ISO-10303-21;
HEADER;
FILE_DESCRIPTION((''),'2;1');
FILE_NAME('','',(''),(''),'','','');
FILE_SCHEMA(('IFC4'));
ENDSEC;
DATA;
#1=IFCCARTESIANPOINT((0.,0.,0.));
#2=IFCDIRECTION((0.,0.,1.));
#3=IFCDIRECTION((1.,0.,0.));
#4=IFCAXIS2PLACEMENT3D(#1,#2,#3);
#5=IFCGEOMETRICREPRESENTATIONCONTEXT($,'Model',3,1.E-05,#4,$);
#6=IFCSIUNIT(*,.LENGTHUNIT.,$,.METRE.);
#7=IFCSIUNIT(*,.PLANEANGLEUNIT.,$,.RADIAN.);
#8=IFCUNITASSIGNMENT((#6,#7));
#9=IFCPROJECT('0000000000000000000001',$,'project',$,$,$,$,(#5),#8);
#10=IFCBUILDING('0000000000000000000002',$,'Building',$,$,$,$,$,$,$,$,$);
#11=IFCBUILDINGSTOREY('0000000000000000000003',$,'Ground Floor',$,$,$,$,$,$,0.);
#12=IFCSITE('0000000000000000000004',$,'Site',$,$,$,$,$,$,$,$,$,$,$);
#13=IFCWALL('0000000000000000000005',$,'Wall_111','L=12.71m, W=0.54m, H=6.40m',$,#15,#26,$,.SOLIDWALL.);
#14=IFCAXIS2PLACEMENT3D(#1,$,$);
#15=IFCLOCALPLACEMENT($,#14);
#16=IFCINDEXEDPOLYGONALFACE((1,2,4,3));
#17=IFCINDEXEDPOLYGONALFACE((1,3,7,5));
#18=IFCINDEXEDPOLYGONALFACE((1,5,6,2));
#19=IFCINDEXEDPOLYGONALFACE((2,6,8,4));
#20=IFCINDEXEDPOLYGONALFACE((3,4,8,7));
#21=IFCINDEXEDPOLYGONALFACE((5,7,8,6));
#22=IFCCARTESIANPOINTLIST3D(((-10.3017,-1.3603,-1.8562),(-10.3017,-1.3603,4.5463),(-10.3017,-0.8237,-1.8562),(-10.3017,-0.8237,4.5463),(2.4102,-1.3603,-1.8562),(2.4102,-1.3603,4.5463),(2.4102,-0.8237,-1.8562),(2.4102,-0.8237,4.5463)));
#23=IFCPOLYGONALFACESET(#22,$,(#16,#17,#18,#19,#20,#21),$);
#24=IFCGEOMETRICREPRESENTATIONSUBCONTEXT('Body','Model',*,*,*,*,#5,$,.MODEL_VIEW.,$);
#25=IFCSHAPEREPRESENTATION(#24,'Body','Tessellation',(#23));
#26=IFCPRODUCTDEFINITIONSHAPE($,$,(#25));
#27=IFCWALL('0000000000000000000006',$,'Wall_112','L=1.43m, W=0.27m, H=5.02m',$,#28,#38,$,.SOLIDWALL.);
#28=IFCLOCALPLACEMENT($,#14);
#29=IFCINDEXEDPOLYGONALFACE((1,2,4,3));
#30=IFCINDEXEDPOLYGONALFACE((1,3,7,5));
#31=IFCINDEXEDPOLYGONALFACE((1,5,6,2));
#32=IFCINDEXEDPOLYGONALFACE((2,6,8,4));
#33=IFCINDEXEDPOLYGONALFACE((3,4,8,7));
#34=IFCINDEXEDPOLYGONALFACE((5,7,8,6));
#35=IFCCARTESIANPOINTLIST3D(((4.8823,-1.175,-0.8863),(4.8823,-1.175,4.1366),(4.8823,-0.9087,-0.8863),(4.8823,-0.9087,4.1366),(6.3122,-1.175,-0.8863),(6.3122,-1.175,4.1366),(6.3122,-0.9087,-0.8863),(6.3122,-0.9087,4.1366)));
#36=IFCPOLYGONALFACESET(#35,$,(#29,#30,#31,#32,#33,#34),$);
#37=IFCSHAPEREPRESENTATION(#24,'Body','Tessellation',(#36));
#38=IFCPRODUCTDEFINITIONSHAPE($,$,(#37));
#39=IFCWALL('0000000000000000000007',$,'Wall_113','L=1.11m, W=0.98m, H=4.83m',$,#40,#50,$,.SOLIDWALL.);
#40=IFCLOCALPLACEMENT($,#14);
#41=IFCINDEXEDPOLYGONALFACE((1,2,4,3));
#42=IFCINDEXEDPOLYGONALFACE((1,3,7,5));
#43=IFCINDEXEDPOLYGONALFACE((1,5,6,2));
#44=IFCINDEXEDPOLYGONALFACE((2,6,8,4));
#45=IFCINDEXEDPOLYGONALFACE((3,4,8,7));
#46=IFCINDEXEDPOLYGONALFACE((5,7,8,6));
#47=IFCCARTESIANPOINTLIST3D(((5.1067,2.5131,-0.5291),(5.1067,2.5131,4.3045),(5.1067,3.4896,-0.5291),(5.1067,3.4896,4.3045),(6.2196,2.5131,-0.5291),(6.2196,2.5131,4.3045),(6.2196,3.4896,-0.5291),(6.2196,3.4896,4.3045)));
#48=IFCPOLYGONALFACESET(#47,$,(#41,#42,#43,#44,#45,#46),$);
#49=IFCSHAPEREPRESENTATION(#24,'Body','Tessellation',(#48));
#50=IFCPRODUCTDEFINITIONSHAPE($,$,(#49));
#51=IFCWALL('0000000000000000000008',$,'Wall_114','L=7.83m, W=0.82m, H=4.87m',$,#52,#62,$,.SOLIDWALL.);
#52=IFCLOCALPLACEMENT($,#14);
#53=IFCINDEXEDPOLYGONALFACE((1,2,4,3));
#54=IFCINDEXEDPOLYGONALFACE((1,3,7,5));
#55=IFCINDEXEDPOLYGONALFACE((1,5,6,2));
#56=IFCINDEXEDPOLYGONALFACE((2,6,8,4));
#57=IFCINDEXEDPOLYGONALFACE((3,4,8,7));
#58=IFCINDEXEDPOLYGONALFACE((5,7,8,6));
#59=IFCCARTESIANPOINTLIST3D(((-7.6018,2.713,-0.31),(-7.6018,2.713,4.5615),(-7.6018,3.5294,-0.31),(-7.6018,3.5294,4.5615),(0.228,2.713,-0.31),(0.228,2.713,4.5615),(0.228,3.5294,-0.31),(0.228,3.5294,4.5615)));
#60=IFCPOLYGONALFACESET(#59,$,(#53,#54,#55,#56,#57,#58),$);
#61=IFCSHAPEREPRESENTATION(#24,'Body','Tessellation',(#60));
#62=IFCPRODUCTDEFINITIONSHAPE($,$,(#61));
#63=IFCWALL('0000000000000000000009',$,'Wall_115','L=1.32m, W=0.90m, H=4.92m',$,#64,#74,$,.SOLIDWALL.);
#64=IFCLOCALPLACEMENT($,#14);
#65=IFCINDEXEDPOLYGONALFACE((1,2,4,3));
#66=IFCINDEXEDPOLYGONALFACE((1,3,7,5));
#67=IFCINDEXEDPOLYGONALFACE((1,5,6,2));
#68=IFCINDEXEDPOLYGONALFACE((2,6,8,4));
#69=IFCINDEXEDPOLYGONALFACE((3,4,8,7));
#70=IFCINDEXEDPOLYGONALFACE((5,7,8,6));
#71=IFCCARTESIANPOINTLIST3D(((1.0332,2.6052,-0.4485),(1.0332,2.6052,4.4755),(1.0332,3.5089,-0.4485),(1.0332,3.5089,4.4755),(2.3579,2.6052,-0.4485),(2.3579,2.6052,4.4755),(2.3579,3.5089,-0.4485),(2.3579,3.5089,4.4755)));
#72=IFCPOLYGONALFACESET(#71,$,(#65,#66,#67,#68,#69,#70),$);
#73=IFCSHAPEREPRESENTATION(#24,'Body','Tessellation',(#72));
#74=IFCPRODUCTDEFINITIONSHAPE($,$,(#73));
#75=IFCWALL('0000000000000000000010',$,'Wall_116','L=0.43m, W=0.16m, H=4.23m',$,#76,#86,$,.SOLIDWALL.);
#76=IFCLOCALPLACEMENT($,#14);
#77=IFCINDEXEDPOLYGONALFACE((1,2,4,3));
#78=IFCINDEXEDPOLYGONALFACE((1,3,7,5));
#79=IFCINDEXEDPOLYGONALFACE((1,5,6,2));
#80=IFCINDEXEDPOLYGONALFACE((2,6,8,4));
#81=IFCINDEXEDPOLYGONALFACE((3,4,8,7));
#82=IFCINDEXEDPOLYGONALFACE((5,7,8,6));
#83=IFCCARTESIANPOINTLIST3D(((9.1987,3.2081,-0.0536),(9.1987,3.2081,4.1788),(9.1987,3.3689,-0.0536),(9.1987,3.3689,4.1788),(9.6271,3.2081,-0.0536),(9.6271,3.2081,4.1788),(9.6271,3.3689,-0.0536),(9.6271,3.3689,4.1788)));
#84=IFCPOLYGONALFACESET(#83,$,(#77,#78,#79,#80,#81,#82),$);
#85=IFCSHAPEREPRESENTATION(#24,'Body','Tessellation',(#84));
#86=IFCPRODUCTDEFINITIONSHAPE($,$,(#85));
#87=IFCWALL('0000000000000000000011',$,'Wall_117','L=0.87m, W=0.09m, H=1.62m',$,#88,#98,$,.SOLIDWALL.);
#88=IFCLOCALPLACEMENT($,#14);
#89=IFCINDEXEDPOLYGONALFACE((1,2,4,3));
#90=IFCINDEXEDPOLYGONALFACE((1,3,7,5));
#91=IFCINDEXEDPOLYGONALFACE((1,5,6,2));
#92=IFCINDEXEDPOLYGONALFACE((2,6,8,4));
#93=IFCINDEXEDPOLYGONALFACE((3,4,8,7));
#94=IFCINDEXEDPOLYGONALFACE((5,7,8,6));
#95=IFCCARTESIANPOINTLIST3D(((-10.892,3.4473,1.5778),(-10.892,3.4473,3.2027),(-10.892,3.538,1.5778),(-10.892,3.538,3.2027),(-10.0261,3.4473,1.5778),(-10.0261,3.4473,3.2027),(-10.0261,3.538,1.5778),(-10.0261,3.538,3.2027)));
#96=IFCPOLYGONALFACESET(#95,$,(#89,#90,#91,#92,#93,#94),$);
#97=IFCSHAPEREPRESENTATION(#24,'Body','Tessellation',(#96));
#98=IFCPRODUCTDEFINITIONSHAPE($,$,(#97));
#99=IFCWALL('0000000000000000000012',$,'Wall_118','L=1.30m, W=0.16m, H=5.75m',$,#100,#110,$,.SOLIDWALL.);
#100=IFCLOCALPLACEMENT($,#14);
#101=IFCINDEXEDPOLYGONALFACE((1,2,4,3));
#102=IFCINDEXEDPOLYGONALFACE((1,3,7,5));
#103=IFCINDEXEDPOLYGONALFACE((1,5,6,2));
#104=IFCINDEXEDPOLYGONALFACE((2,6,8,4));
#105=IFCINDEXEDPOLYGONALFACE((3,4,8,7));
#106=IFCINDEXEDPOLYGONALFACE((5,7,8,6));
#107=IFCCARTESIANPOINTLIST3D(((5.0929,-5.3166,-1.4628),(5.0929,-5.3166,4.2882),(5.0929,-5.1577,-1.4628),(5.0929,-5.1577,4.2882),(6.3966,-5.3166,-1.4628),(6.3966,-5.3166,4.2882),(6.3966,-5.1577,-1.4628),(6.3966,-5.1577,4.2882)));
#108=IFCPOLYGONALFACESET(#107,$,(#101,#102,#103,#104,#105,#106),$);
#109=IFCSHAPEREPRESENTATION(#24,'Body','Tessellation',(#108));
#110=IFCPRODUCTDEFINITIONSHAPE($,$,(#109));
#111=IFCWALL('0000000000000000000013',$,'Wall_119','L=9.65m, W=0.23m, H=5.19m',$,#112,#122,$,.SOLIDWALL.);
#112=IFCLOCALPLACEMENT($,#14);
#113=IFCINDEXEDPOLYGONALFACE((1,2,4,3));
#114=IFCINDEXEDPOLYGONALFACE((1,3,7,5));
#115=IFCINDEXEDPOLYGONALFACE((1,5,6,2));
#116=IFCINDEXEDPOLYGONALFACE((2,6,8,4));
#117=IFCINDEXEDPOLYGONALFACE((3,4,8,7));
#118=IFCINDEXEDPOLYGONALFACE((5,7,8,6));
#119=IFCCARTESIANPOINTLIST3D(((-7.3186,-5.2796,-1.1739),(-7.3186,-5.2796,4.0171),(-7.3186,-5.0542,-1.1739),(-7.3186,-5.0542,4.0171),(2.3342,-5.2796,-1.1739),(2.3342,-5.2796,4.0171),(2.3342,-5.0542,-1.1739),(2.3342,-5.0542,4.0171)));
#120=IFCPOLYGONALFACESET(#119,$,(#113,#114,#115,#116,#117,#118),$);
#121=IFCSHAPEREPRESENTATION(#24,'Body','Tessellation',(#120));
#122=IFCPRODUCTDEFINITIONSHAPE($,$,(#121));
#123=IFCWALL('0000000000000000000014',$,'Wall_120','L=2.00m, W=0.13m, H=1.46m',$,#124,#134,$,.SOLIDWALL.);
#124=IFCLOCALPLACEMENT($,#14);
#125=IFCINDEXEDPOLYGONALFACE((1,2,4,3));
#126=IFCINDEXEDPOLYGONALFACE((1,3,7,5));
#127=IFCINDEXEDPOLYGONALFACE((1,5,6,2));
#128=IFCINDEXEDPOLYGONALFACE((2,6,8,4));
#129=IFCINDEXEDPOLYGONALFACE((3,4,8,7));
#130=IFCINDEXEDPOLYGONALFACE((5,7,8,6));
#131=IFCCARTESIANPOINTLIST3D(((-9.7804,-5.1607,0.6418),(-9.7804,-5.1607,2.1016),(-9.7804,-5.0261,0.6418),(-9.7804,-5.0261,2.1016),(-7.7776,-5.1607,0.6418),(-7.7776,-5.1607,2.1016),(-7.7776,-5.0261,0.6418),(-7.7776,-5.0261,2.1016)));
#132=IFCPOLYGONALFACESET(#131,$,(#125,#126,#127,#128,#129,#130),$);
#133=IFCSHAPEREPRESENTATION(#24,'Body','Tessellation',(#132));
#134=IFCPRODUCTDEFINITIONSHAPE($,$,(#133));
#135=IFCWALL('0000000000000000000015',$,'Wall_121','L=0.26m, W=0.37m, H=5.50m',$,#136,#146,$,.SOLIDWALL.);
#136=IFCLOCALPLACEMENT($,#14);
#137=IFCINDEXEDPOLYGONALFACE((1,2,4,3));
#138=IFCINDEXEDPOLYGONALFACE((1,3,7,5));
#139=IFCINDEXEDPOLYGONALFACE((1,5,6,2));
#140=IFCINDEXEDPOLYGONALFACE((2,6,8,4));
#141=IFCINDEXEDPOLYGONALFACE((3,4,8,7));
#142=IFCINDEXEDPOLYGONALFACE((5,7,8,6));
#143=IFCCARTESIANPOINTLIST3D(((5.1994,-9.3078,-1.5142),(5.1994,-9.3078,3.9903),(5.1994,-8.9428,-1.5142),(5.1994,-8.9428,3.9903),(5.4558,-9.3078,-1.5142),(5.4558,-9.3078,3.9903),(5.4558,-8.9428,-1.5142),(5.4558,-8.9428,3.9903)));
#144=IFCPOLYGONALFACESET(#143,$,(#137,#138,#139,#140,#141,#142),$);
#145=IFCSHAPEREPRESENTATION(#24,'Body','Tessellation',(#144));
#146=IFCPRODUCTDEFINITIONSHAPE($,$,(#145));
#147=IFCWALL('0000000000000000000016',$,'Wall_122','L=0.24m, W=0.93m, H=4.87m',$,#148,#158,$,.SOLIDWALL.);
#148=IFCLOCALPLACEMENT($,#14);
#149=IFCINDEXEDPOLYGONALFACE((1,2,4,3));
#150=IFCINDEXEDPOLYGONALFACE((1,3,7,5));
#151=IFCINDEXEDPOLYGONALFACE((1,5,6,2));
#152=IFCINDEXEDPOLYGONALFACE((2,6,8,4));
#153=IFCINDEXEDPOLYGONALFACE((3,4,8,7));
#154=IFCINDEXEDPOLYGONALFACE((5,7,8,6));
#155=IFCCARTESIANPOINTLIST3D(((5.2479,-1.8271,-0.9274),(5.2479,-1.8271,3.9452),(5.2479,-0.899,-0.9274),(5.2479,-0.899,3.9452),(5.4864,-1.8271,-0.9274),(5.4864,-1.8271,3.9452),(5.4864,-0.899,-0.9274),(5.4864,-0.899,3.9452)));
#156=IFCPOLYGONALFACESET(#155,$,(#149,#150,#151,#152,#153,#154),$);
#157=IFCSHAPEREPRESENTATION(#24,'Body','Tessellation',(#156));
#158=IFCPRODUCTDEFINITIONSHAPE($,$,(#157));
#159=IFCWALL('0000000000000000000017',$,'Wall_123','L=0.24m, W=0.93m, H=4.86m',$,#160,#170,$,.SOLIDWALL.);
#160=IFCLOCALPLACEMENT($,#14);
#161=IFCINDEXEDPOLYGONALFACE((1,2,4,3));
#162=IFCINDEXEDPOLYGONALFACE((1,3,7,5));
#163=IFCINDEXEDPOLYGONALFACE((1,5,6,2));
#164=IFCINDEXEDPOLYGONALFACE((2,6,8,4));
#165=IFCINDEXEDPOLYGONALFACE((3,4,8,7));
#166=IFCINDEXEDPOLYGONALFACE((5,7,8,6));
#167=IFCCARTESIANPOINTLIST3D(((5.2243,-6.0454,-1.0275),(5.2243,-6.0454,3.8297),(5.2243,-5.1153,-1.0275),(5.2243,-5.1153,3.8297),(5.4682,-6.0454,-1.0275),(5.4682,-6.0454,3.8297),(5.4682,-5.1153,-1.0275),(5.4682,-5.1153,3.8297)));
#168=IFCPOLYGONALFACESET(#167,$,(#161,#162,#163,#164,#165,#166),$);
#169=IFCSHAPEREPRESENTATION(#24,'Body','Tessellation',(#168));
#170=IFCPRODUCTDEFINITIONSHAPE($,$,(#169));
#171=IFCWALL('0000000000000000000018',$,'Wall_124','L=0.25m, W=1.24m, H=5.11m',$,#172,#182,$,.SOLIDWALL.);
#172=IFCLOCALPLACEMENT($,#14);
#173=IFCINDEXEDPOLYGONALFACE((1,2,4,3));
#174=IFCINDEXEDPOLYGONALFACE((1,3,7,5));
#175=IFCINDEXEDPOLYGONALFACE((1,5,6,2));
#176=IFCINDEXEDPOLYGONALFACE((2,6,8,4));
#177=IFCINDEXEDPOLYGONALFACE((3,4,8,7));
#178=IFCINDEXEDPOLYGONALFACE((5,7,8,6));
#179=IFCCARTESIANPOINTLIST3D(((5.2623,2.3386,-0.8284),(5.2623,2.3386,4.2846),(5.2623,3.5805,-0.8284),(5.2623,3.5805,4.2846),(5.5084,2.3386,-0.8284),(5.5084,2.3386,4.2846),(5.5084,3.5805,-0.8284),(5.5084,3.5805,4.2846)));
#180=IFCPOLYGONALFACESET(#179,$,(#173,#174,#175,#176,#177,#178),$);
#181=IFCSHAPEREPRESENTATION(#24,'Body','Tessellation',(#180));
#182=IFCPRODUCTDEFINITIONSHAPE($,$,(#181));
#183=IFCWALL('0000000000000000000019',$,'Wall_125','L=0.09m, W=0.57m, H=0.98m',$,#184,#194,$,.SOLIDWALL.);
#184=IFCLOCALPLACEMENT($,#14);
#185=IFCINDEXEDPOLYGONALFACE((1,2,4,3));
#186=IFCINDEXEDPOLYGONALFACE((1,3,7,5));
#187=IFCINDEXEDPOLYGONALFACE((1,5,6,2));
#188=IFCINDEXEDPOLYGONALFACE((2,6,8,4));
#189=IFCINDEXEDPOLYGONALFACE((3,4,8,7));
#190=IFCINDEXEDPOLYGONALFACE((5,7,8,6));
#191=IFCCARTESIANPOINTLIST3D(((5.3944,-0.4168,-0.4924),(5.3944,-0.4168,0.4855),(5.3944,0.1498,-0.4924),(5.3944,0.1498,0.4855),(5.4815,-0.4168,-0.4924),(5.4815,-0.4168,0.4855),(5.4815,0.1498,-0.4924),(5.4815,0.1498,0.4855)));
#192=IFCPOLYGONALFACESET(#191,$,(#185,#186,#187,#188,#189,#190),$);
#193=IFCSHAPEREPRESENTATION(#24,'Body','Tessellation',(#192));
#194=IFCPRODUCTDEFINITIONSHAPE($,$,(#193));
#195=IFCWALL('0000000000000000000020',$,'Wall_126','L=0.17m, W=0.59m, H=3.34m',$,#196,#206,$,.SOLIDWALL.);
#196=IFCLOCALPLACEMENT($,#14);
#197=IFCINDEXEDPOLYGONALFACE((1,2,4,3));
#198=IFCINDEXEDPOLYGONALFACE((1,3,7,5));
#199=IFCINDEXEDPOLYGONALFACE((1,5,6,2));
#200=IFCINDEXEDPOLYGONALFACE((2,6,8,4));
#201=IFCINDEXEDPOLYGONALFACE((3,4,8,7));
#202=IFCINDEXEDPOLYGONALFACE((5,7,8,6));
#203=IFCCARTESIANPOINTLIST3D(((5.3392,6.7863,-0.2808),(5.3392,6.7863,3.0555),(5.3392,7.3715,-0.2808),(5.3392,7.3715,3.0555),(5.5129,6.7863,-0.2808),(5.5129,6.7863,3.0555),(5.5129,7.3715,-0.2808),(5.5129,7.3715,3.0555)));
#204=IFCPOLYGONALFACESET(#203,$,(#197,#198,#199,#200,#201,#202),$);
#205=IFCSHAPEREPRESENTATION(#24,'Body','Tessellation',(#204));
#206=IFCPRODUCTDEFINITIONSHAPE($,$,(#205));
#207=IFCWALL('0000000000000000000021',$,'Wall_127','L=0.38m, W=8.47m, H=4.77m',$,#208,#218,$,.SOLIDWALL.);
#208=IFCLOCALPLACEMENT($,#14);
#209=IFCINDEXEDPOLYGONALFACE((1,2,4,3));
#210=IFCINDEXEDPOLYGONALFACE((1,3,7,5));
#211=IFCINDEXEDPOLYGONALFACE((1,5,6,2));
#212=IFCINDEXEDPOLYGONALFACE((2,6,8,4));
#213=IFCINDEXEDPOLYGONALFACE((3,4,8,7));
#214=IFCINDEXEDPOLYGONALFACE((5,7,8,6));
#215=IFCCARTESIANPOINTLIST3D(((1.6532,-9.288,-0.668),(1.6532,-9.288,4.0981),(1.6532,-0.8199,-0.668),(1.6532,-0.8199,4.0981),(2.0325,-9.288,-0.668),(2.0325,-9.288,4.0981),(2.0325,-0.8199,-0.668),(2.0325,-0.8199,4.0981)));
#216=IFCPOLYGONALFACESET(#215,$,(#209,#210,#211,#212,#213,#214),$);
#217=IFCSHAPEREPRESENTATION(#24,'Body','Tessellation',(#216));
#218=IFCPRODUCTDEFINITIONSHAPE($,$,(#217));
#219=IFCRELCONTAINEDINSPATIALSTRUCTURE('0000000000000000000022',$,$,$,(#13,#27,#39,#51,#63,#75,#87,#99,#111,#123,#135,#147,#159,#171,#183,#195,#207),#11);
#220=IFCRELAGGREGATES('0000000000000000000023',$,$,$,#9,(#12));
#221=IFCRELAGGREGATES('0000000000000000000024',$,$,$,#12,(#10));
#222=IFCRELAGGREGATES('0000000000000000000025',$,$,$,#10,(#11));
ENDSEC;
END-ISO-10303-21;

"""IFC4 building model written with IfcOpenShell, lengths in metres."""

from ifc_helpers import new_model, si_unit, frame, origin_with_axes, origin_2d, context, subcontext, project, spatial, rectangle, extrude, element, save


model = new_model("IFC4")

# Units and contexts
model_context = context("Model", 3, precision=1e-05, world=origin_with_axes())
body_context = subcontext(model_context, "Body", "Model", "MODEL_VIEW")
ifc_project = project(units=[si_unit("LENGTHUNIT", "METRE"), si_unit("PLANEANGLEUNIT", "RADIAN")], contexts=[model_context])

# Site, building, storey
site = spatial("IfcSite", under=ifc_project, Name="Site")
building = spatial("IfcBuilding", under=site, Name="Building")
storey = spatial("IfcBuildingStorey", under=building, Name="Ground Floor", Elevation=0.0)

# Walls
element("IfcWall", 1, inside=storey, Name="Wall_111", Description="L=12.71m, W=0.54m, H=6.40m", PredefinedType="SOLIDWALL", context=body_context, shape_type="SweptSolid", body=[
    extrude(rectangle(XDim=12.7119, YDim=0.5366, at=origin_2d()), frame((-3.9457, -1.092, -1.8562), z_axis=(0.0, 0.0, 1.0), x_axis=(1.0, 0.0, 0.0)), (0.0, 0.0, 1.0), 6.4025),
])
element("IfcWall", 2, inside=storey, Name="Wall_112", Description="L=1.43m, W=0.27m, H=5.02m", PredefinedType="SOLIDWALL", context=body_context, shape_type="SweptSolid", body=[
    extrude(rectangle(XDim=1.43, YDim=0.2663, at=origin_2d()), frame((5.5972, -1.0419, -0.8863), z_axis=(0.0, 0.0, 1.0), x_axis=(1.0, 0.0, 0.0)), (0.0, 0.0, 1.0), 5.0229),
])
element("IfcWall", 3, inside=storey, Name="Wall_113", Description="L=1.11m, W=0.98m, H=4.83m", PredefinedType="SOLIDWALL", context=body_context, shape_type="SweptSolid", body=[
    extrude(rectangle(XDim=1.1129, YDim=0.9766, at=origin_2d()), frame((5.6631, 3.0014, -0.5291), z_axis=(0.0, 0.0, 1.0), x_axis=(1.0, 0.0, 0.0)), (0.0, 0.0, 1.0), 4.8336),
])
element("IfcWall", 4, inside=storey, Name="Wall_114", Description="L=7.83m, W=0.82m, H=4.87m", PredefinedType="SOLIDWALL", context=body_context, shape_type="SweptSolid", body=[
    extrude(rectangle(XDim=7.8298, YDim=0.8164, at=origin_2d()), frame((-3.6869, 3.1212, -0.31), z_axis=(0.0, 0.0, 1.0), x_axis=(1.0, 0.0, 0.0)), (0.0, 0.0, 1.0), 4.8715),
])
element("IfcWall", 5, inside=storey, Name="Wall_115", Description="L=1.32m, W=0.90m, H=4.92m", PredefinedType="SOLIDWALL", context=body_context, shape_type="SweptSolid", body=[
    extrude(rectangle(XDim=1.3247, YDim=0.9036, at=origin_2d()), frame((1.6956, 3.057, -0.4485), z_axis=(0.0, 0.0, 1.0), x_axis=(1.0, 0.0, 0.0)), (0.0, 0.0, 1.0), 4.924),
])
element("IfcWall", 6, inside=storey, Name="Wall_116", Description="L=0.43m, W=0.16m, H=4.23m", PredefinedType="SOLIDWALL", context=body_context, shape_type="SweptSolid", body=[
    extrude(rectangle(XDim=0.4285, YDim=0.1607, at=origin_2d()), frame((9.4129, 3.2885, -0.0536), z_axis=(0.0, 0.0, 1.0), x_axis=(1.0, 0.0, 0.0)), (0.0, 0.0, 1.0), 4.2324),
])
element("IfcWall", 7, inside=storey, Name="Wall_117", Description="L=0.87m, W=0.09m, H=1.62m", PredefinedType="SOLIDWALL", context=body_context, shape_type="SweptSolid", body=[
    extrude(rectangle(XDim=0.8659, YDim=0.0907, at=origin_2d()), frame((-10.4591, 3.4926, 1.5778), z_axis=(0.0, 0.0, 1.0), x_axis=(1.0, 0.0, 0.0)), (0.0, 0.0, 1.0), 1.6249),
])
element("IfcWall", 8, inside=storey, Name="Wall_118", Description="L=1.30m, W=0.16m, H=5.75m", PredefinedType="SOLIDWALL", context=body_context, shape_type="SweptSolid", body=[
    extrude(rectangle(XDim=1.3037, YDim=0.1589, at=origin_2d()), frame((5.7448, -5.2371, -1.4628), z_axis=(0.0, 0.0, 1.0), x_axis=(1.0, 0.0, 0.0)), (0.0, 0.0, 1.0), 5.751),
])
element("IfcWall", 9, inside=storey, Name="Wall_119", Description="L=9.65m, W=0.23m, H=5.19m", PredefinedType="SOLIDWALL", context=body_context, shape_type="SweptSolid", body=[
    extrude(rectangle(XDim=9.6528, YDim=0.2254, at=origin_2d()), frame((-2.4922, -5.1669, -1.1739), z_axis=(0.0, 0.0, 1.0), x_axis=(1.0, 0.0, 0.0)), (0.0, 0.0, 1.0), 5.191),
])
element("IfcWall", 10, inside=storey, Name="Wall_120", Description="L=2.00m, W=0.13m, H=1.46m", PredefinedType="SOLIDWALL", context=body_context, shape_type="SweptSolid", body=[
    extrude(rectangle(XDim=2.0028, YDim=0.1346, at=origin_2d()), frame((-8.779, -5.0934, 0.6418), z_axis=(0.0, 0.0, 1.0), x_axis=(1.0, 0.0, 0.0)), (0.0, 0.0, 1.0), 1.4598),
])
element("IfcWall", 11, inside=storey, Name="Wall_121", Description="L=0.26m, W=0.37m, H=5.50m", PredefinedType="SOLIDWALL", context=body_context, shape_type="SweptSolid", body=[
    extrude(rectangle(XDim=0.2563, YDim=0.365, at=origin_2d()), frame((5.3276, -9.1253, -1.5142), z_axis=(0.0, 0.0, 1.0), x_axis=(1.0, 0.0, 0.0)), (0.0, 0.0, 1.0), 5.5045),
])
element("IfcWall", 12, inside=storey, Name="Wall_122", Description="L=0.24m, W=0.93m, H=4.87m", PredefinedType="SOLIDWALL", context=body_context, shape_type="SweptSolid", body=[
    extrude(rectangle(XDim=0.2385, YDim=0.9281, at=origin_2d()), frame((5.3671, -1.3631, -0.9274), z_axis=(0.0, 0.0, 1.0), x_axis=(1.0, 0.0, 0.0)), (0.0, 0.0, 1.0), 4.8725),
])
element("IfcWall", 13, inside=storey, Name="Wall_123", Description="L=0.24m, W=0.93m, H=4.86m", PredefinedType="SOLIDWALL", context=body_context, shape_type="SweptSolid", body=[
    extrude(rectangle(XDim=0.2439, YDim=0.9301, at=origin_2d()), frame((5.3463, -5.5804, -1.0275), z_axis=(0.0, 0.0, 1.0), x_axis=(1.0, 0.0, 0.0)), (0.0, 0.0, 1.0), 4.8572),
])
element("IfcWall", 14, inside=storey, Name="Wall_124", Description="L=0.25m, W=1.24m, H=5.11m", PredefinedType="SOLIDWALL", context=body_context, shape_type="SweptSolid", body=[
    extrude(rectangle(XDim=0.2461, YDim=1.2418, at=origin_2d()), frame((5.3853, 2.9595, -0.8284), z_axis=(0.0, 0.0, 1.0), x_axis=(1.0, 0.0, 0.0)), (0.0, 0.0, 1.0), 5.113),
])
element("IfcWall", 15, inside=storey, Name="Wall_125", Description="L=0.09m, W=0.57m, H=0.98m", PredefinedType="SOLIDWALL", context=body_context, shape_type="SweptSolid", body=[
    extrude(rectangle(XDim=0.0871, YDim=0.5666, at=origin_2d()), frame((5.438, -0.1335, -0.4924), z_axis=(0.0, 0.0, 1.0), x_axis=(1.0, 0.0, 0.0)), (0.0, 0.0, 1.0), 0.9779),
])
element("IfcWall", 16, inside=storey, Name="Wall_126", Description="L=0.17m, W=0.59m, H=3.34m", PredefinedType="SOLIDWALL", context=body_context, shape_type="SweptSolid", body=[
    extrude(rectangle(XDim=0.1738, YDim=0.5852, at=origin_2d()), frame((5.4261, 7.0789, -0.2808), z_axis=(0.0, 0.0, 1.0), x_axis=(1.0, 0.0, 0.0)), (0.0, 0.0, 1.0), 3.3363),
])
element("IfcWall", 17, inside=storey, Name="Wall_127", Description="L=0.38m, W=8.47m, H=4.77m", PredefinedType="SOLIDWALL", context=body_context, shape_type="SweptSolid", body=[
    extrude(rectangle(XDim=0.3793, YDim=8.4681, at=origin_2d()), frame((1.8429, -5.054, -0.668), z_axis=(0.0, 0.0, 1.0), x_axis=(1.0, 0.0, 0.0)), (0.0, 0.0, 1.0), 4.7661),
])

save(model, "model.ifc")
